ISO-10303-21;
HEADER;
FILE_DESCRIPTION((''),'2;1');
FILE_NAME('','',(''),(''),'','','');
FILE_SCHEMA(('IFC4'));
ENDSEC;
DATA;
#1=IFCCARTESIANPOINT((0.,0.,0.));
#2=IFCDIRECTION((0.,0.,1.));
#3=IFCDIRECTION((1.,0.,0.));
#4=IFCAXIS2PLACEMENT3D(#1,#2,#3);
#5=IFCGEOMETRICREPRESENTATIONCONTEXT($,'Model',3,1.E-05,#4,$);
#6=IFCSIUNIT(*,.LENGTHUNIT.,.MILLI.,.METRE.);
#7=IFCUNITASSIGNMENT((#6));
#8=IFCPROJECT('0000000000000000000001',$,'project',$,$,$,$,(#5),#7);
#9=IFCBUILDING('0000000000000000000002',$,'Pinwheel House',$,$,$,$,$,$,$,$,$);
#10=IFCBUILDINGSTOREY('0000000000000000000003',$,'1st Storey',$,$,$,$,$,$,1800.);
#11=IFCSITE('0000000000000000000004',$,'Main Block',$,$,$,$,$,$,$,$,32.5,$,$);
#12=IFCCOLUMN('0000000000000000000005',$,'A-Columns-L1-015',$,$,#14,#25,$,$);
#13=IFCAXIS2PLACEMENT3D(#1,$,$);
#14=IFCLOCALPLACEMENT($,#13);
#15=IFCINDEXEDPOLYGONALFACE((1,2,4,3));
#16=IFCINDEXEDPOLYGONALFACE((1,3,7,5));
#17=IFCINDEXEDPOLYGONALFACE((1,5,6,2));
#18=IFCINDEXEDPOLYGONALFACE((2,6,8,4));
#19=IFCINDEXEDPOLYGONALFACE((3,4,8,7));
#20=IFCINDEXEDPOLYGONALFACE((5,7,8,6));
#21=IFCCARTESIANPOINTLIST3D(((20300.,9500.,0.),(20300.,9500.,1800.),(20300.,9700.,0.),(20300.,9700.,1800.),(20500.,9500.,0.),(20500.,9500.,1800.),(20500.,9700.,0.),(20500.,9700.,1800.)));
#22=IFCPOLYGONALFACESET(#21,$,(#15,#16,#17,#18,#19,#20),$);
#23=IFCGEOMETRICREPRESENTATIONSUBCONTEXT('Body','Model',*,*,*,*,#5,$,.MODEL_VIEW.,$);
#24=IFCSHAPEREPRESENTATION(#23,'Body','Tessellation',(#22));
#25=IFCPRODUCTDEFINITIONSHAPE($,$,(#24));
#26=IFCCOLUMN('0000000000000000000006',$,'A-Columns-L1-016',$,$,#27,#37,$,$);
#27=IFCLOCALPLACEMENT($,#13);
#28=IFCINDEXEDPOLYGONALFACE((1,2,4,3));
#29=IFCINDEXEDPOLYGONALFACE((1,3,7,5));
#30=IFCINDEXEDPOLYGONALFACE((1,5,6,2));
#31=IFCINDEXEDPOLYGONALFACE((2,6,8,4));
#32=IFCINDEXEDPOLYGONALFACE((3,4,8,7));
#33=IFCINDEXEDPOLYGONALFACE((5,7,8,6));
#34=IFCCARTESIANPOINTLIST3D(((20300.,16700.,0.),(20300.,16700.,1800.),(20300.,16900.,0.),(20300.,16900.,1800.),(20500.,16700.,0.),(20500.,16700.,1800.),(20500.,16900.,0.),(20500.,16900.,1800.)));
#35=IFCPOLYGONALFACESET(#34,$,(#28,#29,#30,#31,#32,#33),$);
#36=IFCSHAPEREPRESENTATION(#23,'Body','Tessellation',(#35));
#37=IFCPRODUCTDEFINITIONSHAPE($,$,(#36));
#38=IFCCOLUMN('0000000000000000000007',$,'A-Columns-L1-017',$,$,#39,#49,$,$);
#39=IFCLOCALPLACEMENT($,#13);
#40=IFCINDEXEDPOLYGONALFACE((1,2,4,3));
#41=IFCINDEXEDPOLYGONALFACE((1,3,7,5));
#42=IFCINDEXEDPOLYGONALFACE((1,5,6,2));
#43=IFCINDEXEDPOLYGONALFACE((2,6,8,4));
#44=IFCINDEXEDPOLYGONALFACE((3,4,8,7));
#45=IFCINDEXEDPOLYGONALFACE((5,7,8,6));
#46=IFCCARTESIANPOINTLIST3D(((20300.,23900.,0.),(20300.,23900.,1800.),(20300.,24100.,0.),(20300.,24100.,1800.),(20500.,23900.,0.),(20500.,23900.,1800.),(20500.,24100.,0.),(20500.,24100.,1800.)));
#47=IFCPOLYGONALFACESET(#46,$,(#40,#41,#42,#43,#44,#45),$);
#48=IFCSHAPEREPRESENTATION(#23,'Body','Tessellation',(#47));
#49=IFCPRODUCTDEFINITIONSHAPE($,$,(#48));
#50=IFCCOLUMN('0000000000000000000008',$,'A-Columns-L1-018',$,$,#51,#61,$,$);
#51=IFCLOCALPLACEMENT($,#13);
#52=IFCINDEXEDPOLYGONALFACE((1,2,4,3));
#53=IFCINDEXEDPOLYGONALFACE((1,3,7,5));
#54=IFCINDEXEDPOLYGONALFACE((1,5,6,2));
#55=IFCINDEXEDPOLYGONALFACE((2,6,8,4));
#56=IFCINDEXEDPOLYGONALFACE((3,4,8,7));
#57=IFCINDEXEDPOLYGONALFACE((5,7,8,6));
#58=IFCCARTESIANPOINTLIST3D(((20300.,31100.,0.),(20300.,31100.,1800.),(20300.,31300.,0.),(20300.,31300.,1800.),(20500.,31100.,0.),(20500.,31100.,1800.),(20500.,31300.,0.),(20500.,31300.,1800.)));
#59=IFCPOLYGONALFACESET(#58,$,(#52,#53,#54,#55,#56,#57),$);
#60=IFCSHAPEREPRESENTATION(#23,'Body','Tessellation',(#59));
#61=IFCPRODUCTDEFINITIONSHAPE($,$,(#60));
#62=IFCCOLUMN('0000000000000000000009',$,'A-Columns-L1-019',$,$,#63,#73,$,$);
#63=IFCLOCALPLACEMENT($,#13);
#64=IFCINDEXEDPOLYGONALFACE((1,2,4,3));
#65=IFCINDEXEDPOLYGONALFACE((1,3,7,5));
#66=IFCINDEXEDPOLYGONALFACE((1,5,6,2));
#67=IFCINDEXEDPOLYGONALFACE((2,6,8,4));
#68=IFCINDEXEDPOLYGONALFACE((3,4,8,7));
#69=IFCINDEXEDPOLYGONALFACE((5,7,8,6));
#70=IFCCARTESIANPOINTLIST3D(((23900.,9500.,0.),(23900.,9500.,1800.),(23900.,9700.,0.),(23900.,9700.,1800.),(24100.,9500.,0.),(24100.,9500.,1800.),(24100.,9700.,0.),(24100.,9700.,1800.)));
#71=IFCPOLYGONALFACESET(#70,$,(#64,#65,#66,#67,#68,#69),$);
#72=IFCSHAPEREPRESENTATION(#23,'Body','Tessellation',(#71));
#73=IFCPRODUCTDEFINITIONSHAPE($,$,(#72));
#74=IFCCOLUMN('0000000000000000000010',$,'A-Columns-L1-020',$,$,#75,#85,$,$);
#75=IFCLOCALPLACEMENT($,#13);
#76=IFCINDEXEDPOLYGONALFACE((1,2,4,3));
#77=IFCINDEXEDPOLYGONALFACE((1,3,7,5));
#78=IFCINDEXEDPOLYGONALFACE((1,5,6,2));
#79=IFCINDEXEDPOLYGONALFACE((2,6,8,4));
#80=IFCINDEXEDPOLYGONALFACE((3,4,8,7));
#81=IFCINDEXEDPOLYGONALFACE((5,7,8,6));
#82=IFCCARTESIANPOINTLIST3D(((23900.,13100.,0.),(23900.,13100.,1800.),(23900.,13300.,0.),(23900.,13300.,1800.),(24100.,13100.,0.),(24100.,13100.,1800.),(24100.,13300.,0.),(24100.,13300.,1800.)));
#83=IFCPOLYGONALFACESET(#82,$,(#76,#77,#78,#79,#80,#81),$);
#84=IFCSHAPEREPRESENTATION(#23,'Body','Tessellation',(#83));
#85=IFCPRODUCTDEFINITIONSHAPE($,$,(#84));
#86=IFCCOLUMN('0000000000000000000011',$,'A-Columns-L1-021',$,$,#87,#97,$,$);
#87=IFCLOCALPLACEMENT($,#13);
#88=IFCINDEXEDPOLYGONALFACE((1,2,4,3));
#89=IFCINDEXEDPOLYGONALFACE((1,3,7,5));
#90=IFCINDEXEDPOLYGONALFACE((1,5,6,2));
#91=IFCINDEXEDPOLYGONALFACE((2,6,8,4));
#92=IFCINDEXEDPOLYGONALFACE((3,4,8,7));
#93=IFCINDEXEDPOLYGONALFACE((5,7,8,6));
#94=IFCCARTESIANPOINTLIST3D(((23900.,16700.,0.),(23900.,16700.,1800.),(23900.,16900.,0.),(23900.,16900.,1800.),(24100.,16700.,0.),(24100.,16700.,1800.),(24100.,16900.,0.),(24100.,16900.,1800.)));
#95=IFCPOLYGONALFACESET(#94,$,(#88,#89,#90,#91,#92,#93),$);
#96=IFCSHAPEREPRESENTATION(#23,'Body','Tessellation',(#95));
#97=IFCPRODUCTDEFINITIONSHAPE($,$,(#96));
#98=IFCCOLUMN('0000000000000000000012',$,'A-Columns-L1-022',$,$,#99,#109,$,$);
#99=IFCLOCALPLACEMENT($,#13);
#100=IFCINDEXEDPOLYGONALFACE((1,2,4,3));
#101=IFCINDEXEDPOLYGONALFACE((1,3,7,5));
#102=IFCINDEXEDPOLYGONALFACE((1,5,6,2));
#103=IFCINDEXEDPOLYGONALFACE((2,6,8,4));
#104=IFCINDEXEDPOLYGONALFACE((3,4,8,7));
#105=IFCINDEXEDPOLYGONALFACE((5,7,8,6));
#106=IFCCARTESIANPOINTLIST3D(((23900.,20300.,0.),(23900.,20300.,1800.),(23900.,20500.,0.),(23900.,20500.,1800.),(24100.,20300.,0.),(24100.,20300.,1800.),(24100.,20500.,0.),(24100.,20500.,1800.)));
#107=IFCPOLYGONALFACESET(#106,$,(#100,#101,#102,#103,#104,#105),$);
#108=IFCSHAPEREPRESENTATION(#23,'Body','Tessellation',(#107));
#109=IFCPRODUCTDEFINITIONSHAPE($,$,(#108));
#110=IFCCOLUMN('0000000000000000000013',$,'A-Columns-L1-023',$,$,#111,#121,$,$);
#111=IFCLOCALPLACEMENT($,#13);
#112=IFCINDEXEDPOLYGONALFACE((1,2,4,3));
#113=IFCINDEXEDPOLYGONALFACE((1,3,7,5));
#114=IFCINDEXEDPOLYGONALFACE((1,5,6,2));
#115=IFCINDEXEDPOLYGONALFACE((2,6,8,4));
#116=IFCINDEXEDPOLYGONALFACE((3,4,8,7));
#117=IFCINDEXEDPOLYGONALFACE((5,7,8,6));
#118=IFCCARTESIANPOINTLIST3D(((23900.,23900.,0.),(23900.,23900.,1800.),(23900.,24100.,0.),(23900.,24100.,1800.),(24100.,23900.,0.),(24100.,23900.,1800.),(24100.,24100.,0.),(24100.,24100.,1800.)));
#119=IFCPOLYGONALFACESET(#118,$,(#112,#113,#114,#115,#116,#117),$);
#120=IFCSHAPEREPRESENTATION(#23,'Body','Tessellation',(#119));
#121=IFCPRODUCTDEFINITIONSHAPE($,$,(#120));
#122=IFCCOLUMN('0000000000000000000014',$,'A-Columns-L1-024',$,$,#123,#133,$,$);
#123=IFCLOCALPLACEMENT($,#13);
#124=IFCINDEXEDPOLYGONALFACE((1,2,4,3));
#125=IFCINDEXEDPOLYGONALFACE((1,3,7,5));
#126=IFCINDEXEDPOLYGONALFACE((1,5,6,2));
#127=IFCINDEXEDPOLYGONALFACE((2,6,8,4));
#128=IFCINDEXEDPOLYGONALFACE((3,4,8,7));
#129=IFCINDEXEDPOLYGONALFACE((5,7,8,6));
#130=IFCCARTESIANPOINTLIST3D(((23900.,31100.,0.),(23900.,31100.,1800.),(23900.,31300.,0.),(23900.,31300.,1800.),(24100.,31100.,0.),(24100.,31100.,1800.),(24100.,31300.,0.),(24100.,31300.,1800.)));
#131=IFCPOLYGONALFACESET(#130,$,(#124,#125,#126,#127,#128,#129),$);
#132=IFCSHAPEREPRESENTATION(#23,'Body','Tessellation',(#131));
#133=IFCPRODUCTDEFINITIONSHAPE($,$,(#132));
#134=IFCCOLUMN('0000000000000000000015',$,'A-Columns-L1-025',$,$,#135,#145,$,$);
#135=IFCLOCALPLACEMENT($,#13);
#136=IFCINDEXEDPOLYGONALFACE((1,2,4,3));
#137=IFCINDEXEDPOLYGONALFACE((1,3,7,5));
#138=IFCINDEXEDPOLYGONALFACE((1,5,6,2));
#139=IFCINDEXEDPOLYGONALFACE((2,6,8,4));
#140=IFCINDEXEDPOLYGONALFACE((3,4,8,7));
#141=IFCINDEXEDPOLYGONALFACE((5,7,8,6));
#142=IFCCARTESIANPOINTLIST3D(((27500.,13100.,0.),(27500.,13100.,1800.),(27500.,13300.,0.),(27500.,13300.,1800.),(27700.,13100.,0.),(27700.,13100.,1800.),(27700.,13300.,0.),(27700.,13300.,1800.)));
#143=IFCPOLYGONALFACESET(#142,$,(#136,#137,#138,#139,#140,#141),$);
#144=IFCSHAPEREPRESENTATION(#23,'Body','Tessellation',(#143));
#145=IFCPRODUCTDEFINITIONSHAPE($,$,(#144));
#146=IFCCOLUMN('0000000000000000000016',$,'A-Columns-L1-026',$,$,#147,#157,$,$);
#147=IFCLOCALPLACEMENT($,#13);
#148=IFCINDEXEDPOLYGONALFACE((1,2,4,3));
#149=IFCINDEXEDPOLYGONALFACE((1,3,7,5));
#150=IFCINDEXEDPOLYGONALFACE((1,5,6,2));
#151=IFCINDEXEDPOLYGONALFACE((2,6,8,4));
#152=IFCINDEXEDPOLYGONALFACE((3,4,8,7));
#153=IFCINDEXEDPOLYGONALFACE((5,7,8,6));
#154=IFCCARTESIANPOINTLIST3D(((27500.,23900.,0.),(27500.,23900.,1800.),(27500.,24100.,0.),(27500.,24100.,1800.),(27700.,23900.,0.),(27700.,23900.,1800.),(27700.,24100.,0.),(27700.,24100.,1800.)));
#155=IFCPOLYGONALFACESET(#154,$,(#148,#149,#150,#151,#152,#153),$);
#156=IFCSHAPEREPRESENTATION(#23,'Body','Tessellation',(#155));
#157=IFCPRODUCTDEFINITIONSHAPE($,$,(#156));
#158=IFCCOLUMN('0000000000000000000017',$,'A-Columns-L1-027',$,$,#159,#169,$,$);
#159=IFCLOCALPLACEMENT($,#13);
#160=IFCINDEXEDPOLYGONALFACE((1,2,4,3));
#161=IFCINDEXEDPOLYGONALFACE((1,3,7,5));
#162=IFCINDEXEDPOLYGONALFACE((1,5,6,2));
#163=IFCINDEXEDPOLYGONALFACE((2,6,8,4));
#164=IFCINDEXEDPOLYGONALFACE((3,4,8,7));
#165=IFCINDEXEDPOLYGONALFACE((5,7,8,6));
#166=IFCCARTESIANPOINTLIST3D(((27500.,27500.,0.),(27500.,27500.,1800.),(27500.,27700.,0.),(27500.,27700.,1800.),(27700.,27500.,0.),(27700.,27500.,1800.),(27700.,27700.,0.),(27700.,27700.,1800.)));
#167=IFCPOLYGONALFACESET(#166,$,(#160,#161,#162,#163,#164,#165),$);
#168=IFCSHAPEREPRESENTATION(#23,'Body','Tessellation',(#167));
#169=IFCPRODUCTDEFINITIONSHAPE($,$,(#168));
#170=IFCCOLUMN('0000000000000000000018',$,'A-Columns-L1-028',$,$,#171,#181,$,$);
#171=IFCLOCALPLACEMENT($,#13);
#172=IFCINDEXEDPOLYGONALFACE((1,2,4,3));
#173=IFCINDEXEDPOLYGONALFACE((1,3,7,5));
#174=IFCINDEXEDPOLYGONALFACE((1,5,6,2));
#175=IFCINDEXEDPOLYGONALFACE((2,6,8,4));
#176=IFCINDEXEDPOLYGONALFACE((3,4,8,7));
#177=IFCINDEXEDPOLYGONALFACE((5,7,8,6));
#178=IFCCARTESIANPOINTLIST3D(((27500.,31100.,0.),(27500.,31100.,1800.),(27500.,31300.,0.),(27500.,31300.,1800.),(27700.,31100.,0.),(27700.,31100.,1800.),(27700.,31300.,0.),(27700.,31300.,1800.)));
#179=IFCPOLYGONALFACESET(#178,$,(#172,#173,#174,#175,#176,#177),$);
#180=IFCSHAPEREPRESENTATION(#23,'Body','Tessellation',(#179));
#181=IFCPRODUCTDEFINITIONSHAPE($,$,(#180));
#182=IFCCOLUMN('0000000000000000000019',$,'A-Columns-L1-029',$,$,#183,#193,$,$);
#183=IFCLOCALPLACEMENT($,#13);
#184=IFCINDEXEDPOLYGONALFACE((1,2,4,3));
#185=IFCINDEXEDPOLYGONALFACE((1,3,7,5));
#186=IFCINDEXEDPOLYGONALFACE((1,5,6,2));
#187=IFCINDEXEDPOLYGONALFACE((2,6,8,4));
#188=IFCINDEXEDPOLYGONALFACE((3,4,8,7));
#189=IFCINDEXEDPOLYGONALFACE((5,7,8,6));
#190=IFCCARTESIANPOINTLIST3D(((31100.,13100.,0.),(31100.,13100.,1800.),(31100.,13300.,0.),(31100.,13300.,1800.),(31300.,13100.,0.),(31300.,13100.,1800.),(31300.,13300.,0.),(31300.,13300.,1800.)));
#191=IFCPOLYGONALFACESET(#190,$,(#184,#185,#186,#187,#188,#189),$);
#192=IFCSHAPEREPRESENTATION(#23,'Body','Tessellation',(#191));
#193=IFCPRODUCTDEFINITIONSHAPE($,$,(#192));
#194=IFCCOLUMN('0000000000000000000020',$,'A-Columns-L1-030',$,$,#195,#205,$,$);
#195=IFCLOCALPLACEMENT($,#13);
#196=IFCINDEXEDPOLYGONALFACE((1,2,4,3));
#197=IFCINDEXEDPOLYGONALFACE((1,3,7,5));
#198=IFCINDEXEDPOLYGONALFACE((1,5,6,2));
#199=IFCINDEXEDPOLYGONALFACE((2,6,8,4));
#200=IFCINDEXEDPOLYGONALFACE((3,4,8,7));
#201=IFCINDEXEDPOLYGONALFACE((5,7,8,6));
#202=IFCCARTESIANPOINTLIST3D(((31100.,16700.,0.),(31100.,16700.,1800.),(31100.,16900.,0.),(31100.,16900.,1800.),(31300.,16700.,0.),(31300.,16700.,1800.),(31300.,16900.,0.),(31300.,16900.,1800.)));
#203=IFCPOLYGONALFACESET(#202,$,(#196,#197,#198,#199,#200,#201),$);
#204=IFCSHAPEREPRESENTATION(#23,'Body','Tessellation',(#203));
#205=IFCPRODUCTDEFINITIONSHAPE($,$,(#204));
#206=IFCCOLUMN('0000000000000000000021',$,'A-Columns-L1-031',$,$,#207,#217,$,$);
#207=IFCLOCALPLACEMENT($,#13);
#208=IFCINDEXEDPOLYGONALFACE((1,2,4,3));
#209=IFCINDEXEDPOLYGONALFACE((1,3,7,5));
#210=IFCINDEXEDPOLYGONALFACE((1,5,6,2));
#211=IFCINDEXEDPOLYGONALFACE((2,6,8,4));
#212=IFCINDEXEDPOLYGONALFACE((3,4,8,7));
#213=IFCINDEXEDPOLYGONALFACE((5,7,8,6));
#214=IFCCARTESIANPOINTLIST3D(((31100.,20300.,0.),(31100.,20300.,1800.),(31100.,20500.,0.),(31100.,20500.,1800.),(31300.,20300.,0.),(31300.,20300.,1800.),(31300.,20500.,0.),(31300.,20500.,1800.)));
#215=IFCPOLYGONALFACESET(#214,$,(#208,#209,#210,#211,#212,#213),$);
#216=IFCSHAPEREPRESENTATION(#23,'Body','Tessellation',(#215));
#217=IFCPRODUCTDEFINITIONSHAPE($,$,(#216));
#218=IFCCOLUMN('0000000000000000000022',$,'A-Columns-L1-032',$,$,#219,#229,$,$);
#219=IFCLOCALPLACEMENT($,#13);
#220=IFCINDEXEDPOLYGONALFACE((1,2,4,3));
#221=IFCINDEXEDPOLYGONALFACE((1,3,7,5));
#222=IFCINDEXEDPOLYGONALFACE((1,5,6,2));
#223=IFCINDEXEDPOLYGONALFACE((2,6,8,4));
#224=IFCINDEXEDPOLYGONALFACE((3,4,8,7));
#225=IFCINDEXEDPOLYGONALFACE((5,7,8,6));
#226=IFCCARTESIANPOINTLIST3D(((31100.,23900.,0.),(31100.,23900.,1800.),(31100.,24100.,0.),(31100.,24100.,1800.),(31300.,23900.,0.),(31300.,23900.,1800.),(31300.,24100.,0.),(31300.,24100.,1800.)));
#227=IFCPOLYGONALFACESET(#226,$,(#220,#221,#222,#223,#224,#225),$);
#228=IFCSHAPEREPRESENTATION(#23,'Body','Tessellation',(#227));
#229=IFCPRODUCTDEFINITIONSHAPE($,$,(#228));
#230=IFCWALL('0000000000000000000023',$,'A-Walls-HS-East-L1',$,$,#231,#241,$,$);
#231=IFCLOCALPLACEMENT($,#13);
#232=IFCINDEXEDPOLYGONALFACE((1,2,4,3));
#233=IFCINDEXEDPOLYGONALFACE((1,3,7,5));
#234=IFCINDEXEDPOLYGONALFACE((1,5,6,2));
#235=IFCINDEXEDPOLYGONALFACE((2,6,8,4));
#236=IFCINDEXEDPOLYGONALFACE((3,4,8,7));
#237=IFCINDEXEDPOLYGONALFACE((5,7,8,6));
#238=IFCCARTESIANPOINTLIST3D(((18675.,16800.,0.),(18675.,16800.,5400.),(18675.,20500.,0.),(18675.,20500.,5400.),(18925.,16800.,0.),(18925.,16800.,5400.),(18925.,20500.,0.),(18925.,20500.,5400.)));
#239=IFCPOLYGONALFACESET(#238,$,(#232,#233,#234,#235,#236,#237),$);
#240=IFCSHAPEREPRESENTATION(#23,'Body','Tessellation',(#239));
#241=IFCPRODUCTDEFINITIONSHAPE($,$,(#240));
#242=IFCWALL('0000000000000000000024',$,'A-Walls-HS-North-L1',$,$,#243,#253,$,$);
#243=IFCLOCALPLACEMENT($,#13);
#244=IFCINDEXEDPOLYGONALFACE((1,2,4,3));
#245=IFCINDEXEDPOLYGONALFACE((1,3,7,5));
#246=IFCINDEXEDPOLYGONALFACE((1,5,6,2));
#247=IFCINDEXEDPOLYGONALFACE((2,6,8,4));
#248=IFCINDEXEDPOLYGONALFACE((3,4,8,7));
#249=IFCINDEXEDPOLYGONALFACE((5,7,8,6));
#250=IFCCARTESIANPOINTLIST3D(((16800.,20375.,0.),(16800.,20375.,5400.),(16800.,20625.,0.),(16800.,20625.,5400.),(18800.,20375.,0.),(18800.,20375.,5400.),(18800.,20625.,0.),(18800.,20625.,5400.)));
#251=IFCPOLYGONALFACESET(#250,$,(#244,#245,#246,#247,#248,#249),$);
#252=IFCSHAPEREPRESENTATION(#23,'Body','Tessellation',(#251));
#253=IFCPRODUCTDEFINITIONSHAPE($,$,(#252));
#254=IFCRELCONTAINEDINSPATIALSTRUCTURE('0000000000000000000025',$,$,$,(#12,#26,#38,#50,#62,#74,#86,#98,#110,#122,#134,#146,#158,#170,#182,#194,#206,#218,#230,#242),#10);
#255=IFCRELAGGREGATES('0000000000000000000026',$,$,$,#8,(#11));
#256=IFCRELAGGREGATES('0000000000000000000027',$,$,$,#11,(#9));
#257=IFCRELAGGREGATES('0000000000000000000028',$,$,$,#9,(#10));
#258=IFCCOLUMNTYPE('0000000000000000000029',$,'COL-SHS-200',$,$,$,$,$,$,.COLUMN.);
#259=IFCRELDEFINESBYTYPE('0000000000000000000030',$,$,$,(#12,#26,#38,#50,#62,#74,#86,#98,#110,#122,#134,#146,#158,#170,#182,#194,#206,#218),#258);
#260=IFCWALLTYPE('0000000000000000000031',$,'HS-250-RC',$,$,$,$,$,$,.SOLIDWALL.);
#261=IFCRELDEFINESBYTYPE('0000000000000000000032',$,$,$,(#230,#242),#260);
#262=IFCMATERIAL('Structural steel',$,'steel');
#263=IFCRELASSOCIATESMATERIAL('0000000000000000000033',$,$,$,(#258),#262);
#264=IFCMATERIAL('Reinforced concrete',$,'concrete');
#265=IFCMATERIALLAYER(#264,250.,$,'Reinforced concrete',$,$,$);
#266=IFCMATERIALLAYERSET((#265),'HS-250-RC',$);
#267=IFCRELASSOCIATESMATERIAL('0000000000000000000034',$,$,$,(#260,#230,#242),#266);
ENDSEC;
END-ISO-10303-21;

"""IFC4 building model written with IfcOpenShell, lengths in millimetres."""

from ifc_helpers import new_model, si_unit, frame, origin_with_axes, place, context, subcontext, project, spatial, indexed_curve, outline, extrude, material, layer, layer_set, layer_usage, type_object, element, save


model = new_model("IFC4")

# Units and contexts
model_context = context("Model", 3, precision=1e-05, world=origin_with_axes())
body_context = subcontext(model_context, "Body", "Model", "MODEL_VIEW")
ifc_project = project(units=[si_unit("LENGTHUNIT", "METRE", prefix="MILLI")], contexts=[model_context])

# Site, building, storey
site = spatial("IfcSite", under=ifc_project, Name="Main Block", RefElevation=32.5)
building = spatial("IfcBuilding", under=site, Name="Pinwheel House")
storey = spatial("IfcBuildingStorey", under=building, Name="1st Storey", Elevation=1800.0)

# Columns
ifc_material_1 = material(Name="Structural steel", Category="steel")
column_type = type_object("IfcColumnType", Name="COL-SHS-200", PredefinedType="COLUMN", material=ifc_material_1)
for number, where, z_axis, x_axis, name in (
    (1, (20400.0, 9600.0, 0.0), (0.0, 0.0, 1.0), (1.0, 0.0, 0.0), "A-Columns-L1-015"),
    (2, (20400.0, 16800.0, 0.0), (0.0, 0.0, 1.0), (1.0, 0.0, 0.0), "A-Columns-L1-016"),
    (3, (20400.0, 24000.0, 0.0), (0.0, 0.0, 1.0), (1.0, 0.0, 0.0), "A-Columns-L1-017"),
    (4, (20400.0, 31200.0, 0.0), (0.0, 0.0, 1.0), (1.0, 0.0, 0.0), "A-Columns-L1-018"),
    (5, (24000.0, 9600.0, 0.0), (0.0, 0.0, 1.0), (1.0, 0.0, 0.0), "A-Columns-L1-019"),
    (6, (24000.0, 13200.0, 0.0), (0.0, 0.0, 1.0), (1.0, 0.0, 0.0), "A-Columns-L1-020"),
    (7, (24000.0, 16800.0, 0.0), (0.0, 0.0, 1.0), (1.0, 0.0, 0.0), "A-Columns-L1-021"),
    (8, (24000.0, 20400.0, 0.0), (0.0, 0.0, 1.0), (1.0, 0.0, 0.0), "A-Columns-L1-022"),
    (9, (24000.0, 24000.0, 0.0), (0.0, 0.0, 1.0), (1.0, 0.0, 0.0), "A-Columns-L1-023"),
    (10, (24000.0, 31200.0, 0.0), (0.0, 0.0, 1.0), (1.0, 0.0, 0.0), "A-Columns-L1-024"),
    (11, (27600.0, 13200.0, 0.0), (0.0, 0.0, 1.0), (1.0, 0.0, 0.0), "A-Columns-L1-025"),
    (12, (27600.0, 24000.0, 0.0), (0.0, 0.0, 1.0), (1.0, 0.0, 0.0), "A-Columns-L1-026"),
    (13, (27600.0, 27600.0, 0.0), (0.0, 0.0, 1.0), (1.0, 0.0, 0.0), "A-Columns-L1-027"),
    (14, (27600.0, 31200.0, 0.0), (0.0, 0.0, 1.0), (1.0, 0.0, 0.0), "A-Columns-L1-028"),
    (15, (31200.0, 13200.0, 0.0), (0.0, 0.0, 1.0), (1.0, 0.0, 0.0), "A-Columns-L1-029"),
    (16, (31200.0, 16800.0, 0.0), (0.0, 0.0, 1.0), (1.0, 0.0, 0.0), "A-Columns-L1-030"),
    (17, (31200.0, 20400.0, 0.0), (0.0, 0.0, 1.0), (1.0, 0.0, 0.0), "A-Columns-L1-031"),
    (18, (31200.0, 24000.0, 0.0), (0.0, 0.0, 1.0), (1.0, 0.0, 0.0), "A-Columns-L1-032"),
):
    element("IfcColumn", number, at=place(None, frame(where, z_axis=z_axis, x_axis=x_axis)), inside=storey, type_object=column_type, Name=name, context=body_context, shape_type="SweptSolid", body=[
        extrude(outline(indexed_curve([(-100.0, -100.0), (100.0, -100.0), (100.0, 100.0), (-100.0, 100.0)])), None, (0.0, 0.0, 1.0), 1800.0),
    ])

# Walls
ifc_material_2 = material(Name="Reinforced concrete", Category="concrete")
ifc_layer_1 = layer(ifc_material_2, 250.0, Name="Reinforced concrete")
ifc_layer_set_1 = layer_set([ifc_layer_1], Name="HS-250-RC")
ifc_layer_usage_1 = layer_usage(ifc_layer_set_1, "AXIS2", "POSITIVE", 0.0)
wall_type_1 = type_object("IfcWallType", Name="HS-250-RC", PredefinedType="SOLIDWALL", material=ifc_layer_set_1)
wall_1_placement = place(None, frame((18925.0, 16800.0, 0.0), z_axis=(0.0, 0.0, 1.0), x_axis=(0.0, 1.0, 0.0)))
element("IfcWall", 19, at=wall_1_placement, inside=storey, type_object=wall_type_1, material=ifc_layer_usage_1, Name="A-Walls-HS-East-L1", context=body_context, shape_type="SweptSolid", body=[
    extrude(outline(indexed_curve([(0.0, 0.0), (0.0, 250.0), (3700.0, 250.0), (3700.0, 0.0), (0.0, 0.0)], self_intersect=False)), origin_with_axes(), (0.0, 0.0, 1.0), 5400.0),
])
ifc_layer_usage_2 = layer_usage(ifc_layer_set_1, "AXIS2", "POSITIVE", 0.0)
wall_2_placement = place(None, frame((18800.0, 20625.0, 0.0), z_axis=(0.0, 0.0, 1.0), x_axis=(-1.0, 0.0, 0.0)))
element("IfcWall", 20, at=wall_2_placement, inside=storey, type_object=wall_type_1, material=ifc_layer_usage_2, Name="A-Walls-HS-North-L1", context=body_context, shape_type="SweptSolid", body=[
    extrude(outline(indexed_curve([(0.0, 0.0), (0.0, 250.0), (2000.0, 250.0), (2000.0, 0.0), (0.0, 0.0)], self_intersect=False)), origin_with_axes(), (0.0, 0.0, 1.0), 5400.0),
])

save(model, "model.ifc")
